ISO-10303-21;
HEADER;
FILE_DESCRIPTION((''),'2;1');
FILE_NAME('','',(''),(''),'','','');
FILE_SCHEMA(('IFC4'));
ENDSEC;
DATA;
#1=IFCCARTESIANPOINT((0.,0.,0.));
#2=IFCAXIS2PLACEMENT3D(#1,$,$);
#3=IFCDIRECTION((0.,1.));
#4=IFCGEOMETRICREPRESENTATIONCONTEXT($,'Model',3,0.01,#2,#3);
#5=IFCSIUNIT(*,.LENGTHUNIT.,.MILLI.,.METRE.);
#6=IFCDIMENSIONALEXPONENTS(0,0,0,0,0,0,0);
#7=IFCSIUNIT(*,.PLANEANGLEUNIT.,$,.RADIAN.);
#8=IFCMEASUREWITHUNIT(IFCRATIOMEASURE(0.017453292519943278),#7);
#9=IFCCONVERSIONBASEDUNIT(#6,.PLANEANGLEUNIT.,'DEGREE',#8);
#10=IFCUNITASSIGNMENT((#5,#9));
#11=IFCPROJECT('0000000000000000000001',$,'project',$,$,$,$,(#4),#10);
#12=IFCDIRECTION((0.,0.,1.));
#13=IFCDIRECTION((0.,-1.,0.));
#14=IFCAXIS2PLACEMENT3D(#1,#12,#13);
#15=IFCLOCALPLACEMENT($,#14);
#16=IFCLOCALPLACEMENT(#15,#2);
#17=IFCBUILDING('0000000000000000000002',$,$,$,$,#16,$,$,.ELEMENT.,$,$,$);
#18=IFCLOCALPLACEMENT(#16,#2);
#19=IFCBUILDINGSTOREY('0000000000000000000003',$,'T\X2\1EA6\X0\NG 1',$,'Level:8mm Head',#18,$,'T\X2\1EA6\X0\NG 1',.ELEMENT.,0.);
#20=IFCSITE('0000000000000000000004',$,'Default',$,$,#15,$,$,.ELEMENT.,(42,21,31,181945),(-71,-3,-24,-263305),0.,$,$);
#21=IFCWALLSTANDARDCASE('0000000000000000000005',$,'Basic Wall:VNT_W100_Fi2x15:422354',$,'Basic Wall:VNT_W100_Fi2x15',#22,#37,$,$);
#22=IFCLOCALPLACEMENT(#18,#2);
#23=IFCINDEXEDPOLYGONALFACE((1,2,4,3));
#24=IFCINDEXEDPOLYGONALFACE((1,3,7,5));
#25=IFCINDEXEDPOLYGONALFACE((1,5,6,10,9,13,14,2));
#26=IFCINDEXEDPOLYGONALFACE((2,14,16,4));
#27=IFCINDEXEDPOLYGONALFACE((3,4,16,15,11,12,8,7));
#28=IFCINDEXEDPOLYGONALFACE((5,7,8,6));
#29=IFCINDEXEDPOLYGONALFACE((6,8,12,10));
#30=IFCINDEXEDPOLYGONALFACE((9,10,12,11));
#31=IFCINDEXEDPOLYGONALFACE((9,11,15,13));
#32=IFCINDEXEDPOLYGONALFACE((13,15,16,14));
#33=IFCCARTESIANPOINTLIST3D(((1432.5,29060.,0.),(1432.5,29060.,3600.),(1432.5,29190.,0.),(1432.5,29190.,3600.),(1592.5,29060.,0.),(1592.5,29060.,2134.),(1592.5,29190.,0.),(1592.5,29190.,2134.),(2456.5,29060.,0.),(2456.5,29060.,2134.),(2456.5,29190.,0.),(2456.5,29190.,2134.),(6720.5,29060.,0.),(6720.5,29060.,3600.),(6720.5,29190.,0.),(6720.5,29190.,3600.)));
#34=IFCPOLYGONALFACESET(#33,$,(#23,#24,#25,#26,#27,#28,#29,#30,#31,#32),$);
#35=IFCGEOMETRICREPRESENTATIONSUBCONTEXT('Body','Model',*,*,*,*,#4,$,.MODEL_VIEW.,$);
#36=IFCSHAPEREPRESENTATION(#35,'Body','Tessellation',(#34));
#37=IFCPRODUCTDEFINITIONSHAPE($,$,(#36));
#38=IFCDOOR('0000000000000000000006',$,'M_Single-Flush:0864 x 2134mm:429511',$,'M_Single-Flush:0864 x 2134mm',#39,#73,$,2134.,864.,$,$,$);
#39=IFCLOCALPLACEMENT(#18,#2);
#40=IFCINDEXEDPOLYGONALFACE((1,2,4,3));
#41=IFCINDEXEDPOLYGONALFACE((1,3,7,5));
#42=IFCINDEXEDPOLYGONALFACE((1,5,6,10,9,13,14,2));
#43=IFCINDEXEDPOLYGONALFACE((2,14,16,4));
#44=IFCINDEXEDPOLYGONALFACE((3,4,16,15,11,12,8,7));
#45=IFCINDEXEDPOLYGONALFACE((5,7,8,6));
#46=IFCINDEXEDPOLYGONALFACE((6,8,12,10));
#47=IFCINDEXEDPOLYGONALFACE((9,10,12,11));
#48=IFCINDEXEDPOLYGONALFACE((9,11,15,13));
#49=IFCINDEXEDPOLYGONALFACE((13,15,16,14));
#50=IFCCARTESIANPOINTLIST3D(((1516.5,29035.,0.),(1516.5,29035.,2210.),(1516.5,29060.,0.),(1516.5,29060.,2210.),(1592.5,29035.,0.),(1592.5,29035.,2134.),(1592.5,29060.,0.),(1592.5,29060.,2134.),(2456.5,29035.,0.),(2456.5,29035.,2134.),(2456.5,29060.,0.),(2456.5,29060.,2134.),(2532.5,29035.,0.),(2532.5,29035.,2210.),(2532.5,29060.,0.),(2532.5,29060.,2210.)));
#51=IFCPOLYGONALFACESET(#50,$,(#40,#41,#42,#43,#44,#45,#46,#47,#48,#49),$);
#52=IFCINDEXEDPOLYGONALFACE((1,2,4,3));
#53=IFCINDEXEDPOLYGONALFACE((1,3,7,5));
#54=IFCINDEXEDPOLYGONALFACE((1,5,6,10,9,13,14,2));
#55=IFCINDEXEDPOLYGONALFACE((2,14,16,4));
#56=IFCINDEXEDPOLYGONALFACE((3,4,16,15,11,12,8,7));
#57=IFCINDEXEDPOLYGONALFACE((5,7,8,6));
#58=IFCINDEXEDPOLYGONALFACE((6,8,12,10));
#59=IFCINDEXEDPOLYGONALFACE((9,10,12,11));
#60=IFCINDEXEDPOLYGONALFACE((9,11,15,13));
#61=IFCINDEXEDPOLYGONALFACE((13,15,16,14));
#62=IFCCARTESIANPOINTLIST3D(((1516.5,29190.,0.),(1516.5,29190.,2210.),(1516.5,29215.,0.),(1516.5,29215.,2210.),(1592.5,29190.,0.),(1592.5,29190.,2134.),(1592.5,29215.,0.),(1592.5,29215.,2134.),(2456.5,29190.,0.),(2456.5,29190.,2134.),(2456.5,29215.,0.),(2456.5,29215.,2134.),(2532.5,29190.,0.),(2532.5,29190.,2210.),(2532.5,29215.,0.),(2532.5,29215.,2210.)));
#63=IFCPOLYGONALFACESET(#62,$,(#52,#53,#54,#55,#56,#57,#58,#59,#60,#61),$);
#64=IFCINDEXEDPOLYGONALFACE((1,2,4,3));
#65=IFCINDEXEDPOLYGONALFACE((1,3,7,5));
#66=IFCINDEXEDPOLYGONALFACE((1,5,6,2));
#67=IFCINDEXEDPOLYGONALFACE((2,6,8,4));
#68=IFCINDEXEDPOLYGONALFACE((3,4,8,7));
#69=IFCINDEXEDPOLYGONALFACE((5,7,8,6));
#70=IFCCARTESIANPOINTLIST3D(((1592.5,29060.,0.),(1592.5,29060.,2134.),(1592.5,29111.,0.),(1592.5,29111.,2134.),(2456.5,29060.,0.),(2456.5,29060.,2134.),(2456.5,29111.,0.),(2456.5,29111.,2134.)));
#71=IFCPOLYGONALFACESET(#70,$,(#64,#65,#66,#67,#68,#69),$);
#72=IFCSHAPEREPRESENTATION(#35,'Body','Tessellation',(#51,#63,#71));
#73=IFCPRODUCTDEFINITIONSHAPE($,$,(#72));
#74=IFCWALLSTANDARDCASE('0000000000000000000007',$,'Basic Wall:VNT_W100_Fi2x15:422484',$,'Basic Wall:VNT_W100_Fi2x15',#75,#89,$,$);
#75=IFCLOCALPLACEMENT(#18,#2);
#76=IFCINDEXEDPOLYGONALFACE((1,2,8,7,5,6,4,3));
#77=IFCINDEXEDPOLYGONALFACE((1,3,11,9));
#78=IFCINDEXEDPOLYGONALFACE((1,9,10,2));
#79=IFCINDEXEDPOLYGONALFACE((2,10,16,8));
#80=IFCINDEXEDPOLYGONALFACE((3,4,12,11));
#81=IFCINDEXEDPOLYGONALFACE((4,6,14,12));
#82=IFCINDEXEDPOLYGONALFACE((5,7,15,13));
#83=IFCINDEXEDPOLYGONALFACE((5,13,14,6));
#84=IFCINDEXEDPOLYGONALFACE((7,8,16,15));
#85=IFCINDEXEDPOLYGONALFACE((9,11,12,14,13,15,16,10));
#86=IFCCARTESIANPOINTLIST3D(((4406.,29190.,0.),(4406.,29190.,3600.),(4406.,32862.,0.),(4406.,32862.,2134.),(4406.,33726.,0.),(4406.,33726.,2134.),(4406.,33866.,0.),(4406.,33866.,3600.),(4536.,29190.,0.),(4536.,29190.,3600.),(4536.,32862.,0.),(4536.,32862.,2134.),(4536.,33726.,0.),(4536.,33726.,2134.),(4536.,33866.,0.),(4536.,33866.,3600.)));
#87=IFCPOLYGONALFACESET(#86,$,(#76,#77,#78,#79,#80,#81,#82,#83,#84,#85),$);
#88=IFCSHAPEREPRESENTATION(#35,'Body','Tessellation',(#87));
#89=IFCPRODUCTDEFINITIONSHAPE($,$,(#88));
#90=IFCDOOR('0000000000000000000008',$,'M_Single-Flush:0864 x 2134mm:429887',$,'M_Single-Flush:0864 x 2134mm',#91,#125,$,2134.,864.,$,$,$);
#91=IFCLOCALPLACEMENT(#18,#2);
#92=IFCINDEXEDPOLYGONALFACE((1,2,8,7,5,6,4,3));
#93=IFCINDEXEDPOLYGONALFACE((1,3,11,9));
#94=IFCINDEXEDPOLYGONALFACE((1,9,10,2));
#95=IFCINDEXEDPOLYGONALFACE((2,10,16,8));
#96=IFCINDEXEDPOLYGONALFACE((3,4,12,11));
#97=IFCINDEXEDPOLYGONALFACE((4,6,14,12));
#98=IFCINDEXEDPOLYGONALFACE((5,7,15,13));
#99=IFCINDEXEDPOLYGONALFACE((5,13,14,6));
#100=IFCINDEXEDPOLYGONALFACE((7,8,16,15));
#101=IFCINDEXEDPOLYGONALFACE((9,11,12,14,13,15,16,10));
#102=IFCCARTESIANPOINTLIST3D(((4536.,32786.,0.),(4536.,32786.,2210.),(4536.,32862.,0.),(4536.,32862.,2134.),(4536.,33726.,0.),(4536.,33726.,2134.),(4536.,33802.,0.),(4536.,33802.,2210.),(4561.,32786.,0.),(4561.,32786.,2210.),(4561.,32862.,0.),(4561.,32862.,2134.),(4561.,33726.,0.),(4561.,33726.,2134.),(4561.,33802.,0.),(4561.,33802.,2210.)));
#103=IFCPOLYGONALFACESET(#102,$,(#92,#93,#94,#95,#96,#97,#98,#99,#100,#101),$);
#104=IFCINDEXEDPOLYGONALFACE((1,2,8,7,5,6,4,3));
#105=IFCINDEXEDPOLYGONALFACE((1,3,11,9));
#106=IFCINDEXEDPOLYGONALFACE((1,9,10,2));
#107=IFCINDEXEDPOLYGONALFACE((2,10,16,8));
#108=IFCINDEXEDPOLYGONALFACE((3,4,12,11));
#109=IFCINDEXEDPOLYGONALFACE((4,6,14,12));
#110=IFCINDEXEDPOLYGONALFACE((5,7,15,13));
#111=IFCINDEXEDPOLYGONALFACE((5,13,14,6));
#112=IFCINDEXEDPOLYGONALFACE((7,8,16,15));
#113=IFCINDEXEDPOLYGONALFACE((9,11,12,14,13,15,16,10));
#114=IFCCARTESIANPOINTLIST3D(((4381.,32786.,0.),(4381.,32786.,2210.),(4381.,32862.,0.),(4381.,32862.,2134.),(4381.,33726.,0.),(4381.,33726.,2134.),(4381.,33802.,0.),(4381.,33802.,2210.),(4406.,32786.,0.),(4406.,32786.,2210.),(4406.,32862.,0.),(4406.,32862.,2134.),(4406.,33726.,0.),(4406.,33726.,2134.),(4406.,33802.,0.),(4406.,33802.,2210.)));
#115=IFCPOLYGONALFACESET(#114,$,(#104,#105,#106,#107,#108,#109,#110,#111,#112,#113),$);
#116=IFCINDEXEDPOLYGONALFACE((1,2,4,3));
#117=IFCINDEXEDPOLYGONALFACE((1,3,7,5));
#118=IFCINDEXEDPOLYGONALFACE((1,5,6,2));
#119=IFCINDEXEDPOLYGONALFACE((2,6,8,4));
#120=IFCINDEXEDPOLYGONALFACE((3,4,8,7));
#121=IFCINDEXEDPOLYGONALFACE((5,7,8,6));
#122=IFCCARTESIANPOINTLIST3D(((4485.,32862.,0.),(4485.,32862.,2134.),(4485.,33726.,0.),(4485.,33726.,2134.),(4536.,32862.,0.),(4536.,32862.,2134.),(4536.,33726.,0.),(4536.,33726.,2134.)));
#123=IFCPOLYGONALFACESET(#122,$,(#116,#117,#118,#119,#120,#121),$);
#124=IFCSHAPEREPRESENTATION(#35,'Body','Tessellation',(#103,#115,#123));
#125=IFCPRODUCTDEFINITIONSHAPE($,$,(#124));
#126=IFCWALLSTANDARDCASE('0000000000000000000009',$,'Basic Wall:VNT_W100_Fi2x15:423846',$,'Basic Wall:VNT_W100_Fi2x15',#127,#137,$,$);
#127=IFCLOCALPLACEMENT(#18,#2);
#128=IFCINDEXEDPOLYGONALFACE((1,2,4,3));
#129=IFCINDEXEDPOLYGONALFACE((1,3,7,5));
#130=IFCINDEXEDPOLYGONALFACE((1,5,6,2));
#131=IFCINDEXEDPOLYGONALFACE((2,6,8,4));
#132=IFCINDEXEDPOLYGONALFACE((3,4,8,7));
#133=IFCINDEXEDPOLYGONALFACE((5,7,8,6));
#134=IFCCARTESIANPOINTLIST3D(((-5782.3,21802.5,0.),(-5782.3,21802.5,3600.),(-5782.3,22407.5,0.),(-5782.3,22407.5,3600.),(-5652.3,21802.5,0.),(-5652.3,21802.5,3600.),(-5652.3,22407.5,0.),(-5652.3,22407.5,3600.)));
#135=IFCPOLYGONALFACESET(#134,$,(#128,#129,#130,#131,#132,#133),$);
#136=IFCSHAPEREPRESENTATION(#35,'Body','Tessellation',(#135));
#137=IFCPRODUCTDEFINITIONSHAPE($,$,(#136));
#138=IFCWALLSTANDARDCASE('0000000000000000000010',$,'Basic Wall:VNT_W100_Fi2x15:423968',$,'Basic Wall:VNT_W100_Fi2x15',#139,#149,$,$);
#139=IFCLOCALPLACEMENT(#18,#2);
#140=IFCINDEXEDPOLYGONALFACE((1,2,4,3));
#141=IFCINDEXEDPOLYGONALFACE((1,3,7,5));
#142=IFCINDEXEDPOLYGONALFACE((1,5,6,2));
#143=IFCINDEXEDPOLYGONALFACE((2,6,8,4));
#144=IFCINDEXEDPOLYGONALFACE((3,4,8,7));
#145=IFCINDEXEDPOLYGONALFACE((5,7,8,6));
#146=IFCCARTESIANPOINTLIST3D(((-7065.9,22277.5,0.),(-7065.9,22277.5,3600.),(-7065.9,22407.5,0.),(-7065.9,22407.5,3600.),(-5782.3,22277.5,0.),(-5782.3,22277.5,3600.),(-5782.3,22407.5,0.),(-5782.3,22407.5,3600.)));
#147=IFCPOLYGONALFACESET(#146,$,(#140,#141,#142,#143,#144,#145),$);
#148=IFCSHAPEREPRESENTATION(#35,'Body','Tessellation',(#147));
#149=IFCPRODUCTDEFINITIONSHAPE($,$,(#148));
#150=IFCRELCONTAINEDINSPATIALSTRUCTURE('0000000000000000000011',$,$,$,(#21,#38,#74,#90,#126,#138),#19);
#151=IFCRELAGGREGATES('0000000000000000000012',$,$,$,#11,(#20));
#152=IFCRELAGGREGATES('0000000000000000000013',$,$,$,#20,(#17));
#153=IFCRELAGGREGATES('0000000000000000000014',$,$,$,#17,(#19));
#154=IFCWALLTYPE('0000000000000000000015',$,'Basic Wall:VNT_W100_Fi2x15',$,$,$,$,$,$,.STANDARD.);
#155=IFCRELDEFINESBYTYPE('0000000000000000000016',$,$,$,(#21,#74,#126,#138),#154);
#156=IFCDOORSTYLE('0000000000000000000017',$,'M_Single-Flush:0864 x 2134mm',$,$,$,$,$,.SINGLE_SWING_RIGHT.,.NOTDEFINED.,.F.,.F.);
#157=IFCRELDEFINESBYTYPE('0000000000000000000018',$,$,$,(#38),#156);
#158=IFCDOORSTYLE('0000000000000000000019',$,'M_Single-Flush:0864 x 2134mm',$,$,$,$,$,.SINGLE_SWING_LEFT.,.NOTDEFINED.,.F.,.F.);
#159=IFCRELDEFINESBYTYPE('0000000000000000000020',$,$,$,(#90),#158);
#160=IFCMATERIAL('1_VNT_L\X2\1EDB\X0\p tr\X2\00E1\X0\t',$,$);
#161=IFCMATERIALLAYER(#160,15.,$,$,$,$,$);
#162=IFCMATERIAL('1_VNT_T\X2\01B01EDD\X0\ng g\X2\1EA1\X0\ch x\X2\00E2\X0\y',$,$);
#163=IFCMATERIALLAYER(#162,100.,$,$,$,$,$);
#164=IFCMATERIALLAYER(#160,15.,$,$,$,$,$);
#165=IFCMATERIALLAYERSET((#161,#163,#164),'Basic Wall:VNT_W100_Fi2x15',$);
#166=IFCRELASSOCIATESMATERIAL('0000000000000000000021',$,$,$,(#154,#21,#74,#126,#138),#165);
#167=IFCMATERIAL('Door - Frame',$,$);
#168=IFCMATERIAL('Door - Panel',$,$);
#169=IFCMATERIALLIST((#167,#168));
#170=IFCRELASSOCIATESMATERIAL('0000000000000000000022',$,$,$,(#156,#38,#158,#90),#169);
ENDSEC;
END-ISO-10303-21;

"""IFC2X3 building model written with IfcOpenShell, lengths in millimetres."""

from ifc_helpers import new_model, entity, si_unit, converted_unit, direction, frame, frame_2d, origin, place, context, subcontext, project, spatial, polyline, rectangle, outline, extrude, source, transform, mapped, material, material_list, layer, layer_set, layer_usage, type_object, type_shapes, element, fill, save


model = new_model("IFC2X3")

# Units and contexts
model_context = context("Model", 3, precision=0.01, world=origin(), true_north=direction((0.0, 1.0)))
body_context = subcontext(model_context, "Body", "Model", "MODEL_VIEW")
ifc_project = project(units=[si_unit("LENGTHUNIT", "METRE", prefix="MILLI"), converted_unit("PLANEANGLEUNIT", "DEGREE", entity("IfcRatioMeasure", 0.017453292519943278), si_unit("PLANEANGLEUNIT", "RADIAN"), dimensions=[0, 0, 0, 0, 0, 0, 0])], contexts=[model_context])

# Site, building, storey
site_placement = place(None, frame((0.0, 0.0, 0.0), z_axis=(0.0, 0.0, 1.0), x_axis=(0.0, -1.0, 0.0)))
site = spatial("IfcSite", under=ifc_project, at=site_placement, Name="Default", CompositionType="ELEMENT", RefLatitude=(42, 21, 31, 181945), RefLongitude=(-71, -3, -24, -263305), RefElevation=0.0)
building_placement = place(site_placement, origin())
building = spatial("IfcBuilding", under=site, at=building_placement, CompositionType="ELEMENT")
storey_placement = place(building_placement, origin())
storey = spatial("IfcBuildingStorey", under=building, at=storey_placement, Name="TẦNG 1", ObjectType="Level:8mm Head", LongName="TẦNG 1", CompositionType="ELEMENT", Elevation=0.0)

# Shared definitions
ifc_material_1 = material(Name="1_VNT_Lớp trát")
ifc_material_2 = material(Name="1_VNT_Tường gạch xây")

# Shared definitions
ifc_layer_1 = layer(ifc_material_1, 15.0)
ifc_layer_2 = layer(ifc_material_2, 100.0)
ifc_layer_3 = layer(ifc_material_1, 15.0)
ifc_layer_set_1 = layer_set([ifc_layer_1, ifc_layer_2, ifc_layer_3], Name="Basic Wall:VNT_W100_Fi2x15")
ifc_layer_usage_1 = layer_usage(ifc_layer_set_1, "AXIS2", "NEGATIVE", 65.0)
wall_type_1 = type_object("IfcWallType", Name="Basic Wall:VNT_W100_Fi2x15", PredefinedType="STANDARD", material=ifc_layer_set_1)

# Walls, openings, doors
wall_1_placement = place(storey_placement, frame((1432.5, 29125.0, 0.0)))
wall_1 = element("IfcWallStandardCase", 1, at=wall_1_placement, inside=storey, type_object=wall_type_1, material=ifc_layer_usage_1, Name="Basic Wall:VNT_W100_Fi2x15:422354", ObjectType="Basic Wall:VNT_W100_Fi2x15", context=body_context, shape_type="SweptSolid", body=[
    extrude(rectangle(XDim=5288.0, YDim=130.0, at=frame_2d((2644.0, 0.0), x_axis=(1.0, 0.0))), origin(), (0.0, 0.0, 1.0), 3600.0),
])
opening_1_placement = place(wall_1_placement, frame((1024.0, 65.0, 0.0)))
opening_1 = element("IfcOpeningElement", 2, at=opening_1_placement, cuts=wall_1, ObjectType="Opening", context=body_context, shape_type="SweptSolid", body=[
    extrude(rectangle(XDim=864.0, YDim=2134.0, at=frame_2d((1067.0, 432.0), x_axis=(0.0, 1.0))), frame((0.0, 0.0, 0.0), z_axis=(0.0, -1.0, 0.0), x_axis=(0.0, 0.0, 1.0)), (0.0, 0.0, 1.0), 130.0),
])
ifc_material_3 = material(Name="Door - Frame")
ifc_material_4 = material(Name="Door - Panel")
ifc_material_list = material_list([ifc_material_3, ifc_material_4])
door_style_1 = type_object("IfcDoorStyle", Name="M_Single-Flush:0864 x 2134mm", ConstructionType="NOTDEFINED", OperationType="SINGLE_SWING_RIGHT", ParameterTakesPrecedence=False, Sizeable=False, material=ifc_material_list)
shared_shape_1 = source(origin(), body_context, "Body", "SweptSolid", [
    extrude(outline(polyline([(-508.0, -1124.0), (508.0, -1124.0), (508.0, 1086.0), (432.0, 1086.0), (432.0, -1048.0), (-432.0, -1048.0), (-432.0, 1086.0), (-508.0, 1086.0), (-508.0, -1124.0)])), frame((432.0, 130.0, 1086.0), z_axis=(0.0, 1.0, 0.0), x_axis=(1.0, 0.0, 0.0)), (0.0, 0.0, 1.0), 25.0),
    extrude(outline(polyline([(-1124.0, -508.0), (1086.0, -508.0), (1086.0, -432.0), (-1048.0, -432.0), (-1048.0, 432.0), (1086.0, 432.0), (1086.0, 508.0), (-1124.0, 508.0), (-1124.0, -508.0)])), frame((432.0, -25.0, 1086.0), z_axis=(0.0, 1.0, 0.0), x_axis=(0.0, 0.0, -1.0)), (0.0, 0.0, 1.0), 25.0),
    extrude(rectangle(XDim=51.0, YDim=864.0, at=frame_2d((0.0, 0.0), x_axis=(1.0, 0.0))), frame((432.0, 104.5, 0.0), z_axis=(0.0, 0.0, 1.0), x_axis=(0.0, 1.0, 0.0)), (0.0, 0.0, 1.0), 2134.0),
])
type_shapes(door_style_1, [shared_shape_1])
door_1_placement = place(opening_1_placement, frame((0.0, 0.0, 0.0), z_axis=(0.0, 0.0, 1.0), x_axis=(-1.0, 0.0, 0.0)))
door_1 = element("IfcDoor", 3, at=door_1_placement, inside=storey, type_object=door_style_1, material=ifc_material_list, Name="M_Single-Flush:0864 x 2134mm:429511", ObjectType="M_Single-Flush:0864 x 2134mm", OverallHeight=2134.0, OverallWidth=864.0, context=body_context, shape_type="MappedRepresentation", body=[
    mapped(shared_shape_1, transform((0.0, 0.0, 0.0), scale=1.0)),
])
fill(opening_1, door_1)
wall_2_placement = place(storey_placement, frame((4471.0, 29190.0, 0.0), z_axis=(0.0, 0.0, 1.0), x_axis=(0.0, 1.0, 0.0)))
wall_2 = element("IfcWallStandardCase", 4, at=wall_2_placement, inside=storey, type_object=wall_type_1, material=ifc_layer_usage_1, Name="Basic Wall:VNT_W100_Fi2x15:422484", ObjectType="Basic Wall:VNT_W100_Fi2x15", context=body_context, shape_type="SweptSolid", body=[
    extrude(rectangle(XDim=4676.0, YDim=130.0, at=frame_2d((2338.0, 0.0), x_axis=(1.0, 0.0))), origin(), (0.0, 0.0, 1.0), 3600.0),
])
opening_2_placement = place(wall_2_placement, frame((4536.0, 65.0, 0.0)))
opening_2 = element("IfcOpeningElement", 5, at=opening_2_placement, cuts=wall_2, ObjectType="Opening", context=body_context, shape_type="SweptSolid", body=[
    extrude(rectangle(XDim=864.0, YDim=2134.0, at=frame_2d((1067.0, 432.0), x_axis=(0.0, -1.0))), frame((0.0, 0.0, 0.0), z_axis=(0.0, -1.0, 0.0), x_axis=(0.0, 0.0, 1.0)), (0.0, 0.0, 1.0), 130.0),
])
door_style_2 = type_object("IfcDoorStyle", Name="M_Single-Flush:0864 x 2134mm", ConstructionType="NOTDEFINED", OperationType="SINGLE_SWING_LEFT", ParameterTakesPrecedence=False, Sizeable=False, material=ifc_material_list)
shared_shape_2 = source(origin(), body_context, "Body", "SweptSolid", [
    extrude(outline(polyline([(-508.0, -1124.0), (508.0, -1124.0), (508.0, 1086.0), (432.0, 1086.0), (432.0, -1048.0), (-432.0, -1048.0), (-432.0, 1086.0), (-508.0, 1086.0), (-508.0, -1124.0)])), frame((432.0, 155.0, 1086.0), z_axis=(0.0, -1.0, 0.0), x_axis=(-1.0, 0.0, 0.0)), (0.0, 0.0, 1.0), 25.0),
    extrude(outline(polyline([(-1124.0, -508.0), (1086.0, -508.0), (1086.0, -432.0), (-1048.0, -432.0), (-1048.0, 432.0), (1086.0, 432.0), (1086.0, 508.0), (-1124.0, 508.0), (-1124.0, -508.0)])), frame((432.0, 0.0, 1086.0), z_axis=(0.0, -1.0, 0.0), x_axis=(0.0, 0.0, -1.0)), (0.0, 0.0, 1.0), 25.0),
    extrude(rectangle(XDim=864.0, YDim=51.0, at=frame_2d((0.0, 0.0), x_axis=(1.0, 0.0))), frame((432.0, 104.5, 0.0)), (0.0, 0.0, 1.0), 2134.0),
])
type_shapes(door_style_2, [shared_shape_2])
door_2_placement = place(opening_2_placement, frame((0.0, 0.0, 0.0), z_axis=(0.0, 0.0, 1.0), x_axis=(-1.0, 0.0, 0.0)))
door_2 = element("IfcDoor", 6, at=door_2_placement, inside=storey, type_object=door_style_2, material=ifc_material_list, Name="M_Single-Flush:0864 x 2134mm:429887", ObjectType="M_Single-Flush:0864 x 2134mm", OverallHeight=2134.0, OverallWidth=864.0, context=body_context, shape_type="MappedRepresentation", body=[
    mapped(shared_shape_2, transform((0.0, 0.0, 0.0), scale=1.0)),
])
fill(opening_2, door_2)

# Walls
wall_3_placement = place(storey_placement, frame((-5717.3, 21802.5, 0.0), z_axis=(0.0, 0.0, 1.0), x_axis=(0.0, 1.0, 0.0)))
element("IfcWallStandardCase", 7, at=wall_3_placement, inside=storey, type_object=wall_type_1, material=ifc_layer_usage_1, Name="Basic Wall:VNT_W100_Fi2x15:423846", ObjectType="Basic Wall:VNT_W100_Fi2x15", context=body_context, shape_type="SweptSolid", body=[
    extrude(rectangle(XDim=605.0, YDim=130.0, at=frame_2d((302.5, 0.0), x_axis=(-1.0, 0.0))), origin(), (0.0, 0.0, 1.0), 3600.0),
])
wall_4_placement = place(storey_placement, frame((-5782.3, 22342.5, 0.0), z_axis=(0.0, 0.0, 1.0), x_axis=(-1.0, 0.0, 0.0)))
element("IfcWallStandardCase", 8, at=wall_4_placement, inside=storey, type_object=wall_type_1, material=ifc_layer_usage_1, Name="Basic Wall:VNT_W100_Fi2x15:423968", ObjectType="Basic Wall:VNT_W100_Fi2x15", context=body_context, shape_type="SweptSolid", body=[
    extrude(rectangle(XDim=1283.7, YDim=130.0, at=frame_2d((641.8, 0.0), x_axis=(-1.0, 0.0))), origin(), (0.0, 0.0, 1.0), 3600.0),
])

save(model, "model.ifc")
